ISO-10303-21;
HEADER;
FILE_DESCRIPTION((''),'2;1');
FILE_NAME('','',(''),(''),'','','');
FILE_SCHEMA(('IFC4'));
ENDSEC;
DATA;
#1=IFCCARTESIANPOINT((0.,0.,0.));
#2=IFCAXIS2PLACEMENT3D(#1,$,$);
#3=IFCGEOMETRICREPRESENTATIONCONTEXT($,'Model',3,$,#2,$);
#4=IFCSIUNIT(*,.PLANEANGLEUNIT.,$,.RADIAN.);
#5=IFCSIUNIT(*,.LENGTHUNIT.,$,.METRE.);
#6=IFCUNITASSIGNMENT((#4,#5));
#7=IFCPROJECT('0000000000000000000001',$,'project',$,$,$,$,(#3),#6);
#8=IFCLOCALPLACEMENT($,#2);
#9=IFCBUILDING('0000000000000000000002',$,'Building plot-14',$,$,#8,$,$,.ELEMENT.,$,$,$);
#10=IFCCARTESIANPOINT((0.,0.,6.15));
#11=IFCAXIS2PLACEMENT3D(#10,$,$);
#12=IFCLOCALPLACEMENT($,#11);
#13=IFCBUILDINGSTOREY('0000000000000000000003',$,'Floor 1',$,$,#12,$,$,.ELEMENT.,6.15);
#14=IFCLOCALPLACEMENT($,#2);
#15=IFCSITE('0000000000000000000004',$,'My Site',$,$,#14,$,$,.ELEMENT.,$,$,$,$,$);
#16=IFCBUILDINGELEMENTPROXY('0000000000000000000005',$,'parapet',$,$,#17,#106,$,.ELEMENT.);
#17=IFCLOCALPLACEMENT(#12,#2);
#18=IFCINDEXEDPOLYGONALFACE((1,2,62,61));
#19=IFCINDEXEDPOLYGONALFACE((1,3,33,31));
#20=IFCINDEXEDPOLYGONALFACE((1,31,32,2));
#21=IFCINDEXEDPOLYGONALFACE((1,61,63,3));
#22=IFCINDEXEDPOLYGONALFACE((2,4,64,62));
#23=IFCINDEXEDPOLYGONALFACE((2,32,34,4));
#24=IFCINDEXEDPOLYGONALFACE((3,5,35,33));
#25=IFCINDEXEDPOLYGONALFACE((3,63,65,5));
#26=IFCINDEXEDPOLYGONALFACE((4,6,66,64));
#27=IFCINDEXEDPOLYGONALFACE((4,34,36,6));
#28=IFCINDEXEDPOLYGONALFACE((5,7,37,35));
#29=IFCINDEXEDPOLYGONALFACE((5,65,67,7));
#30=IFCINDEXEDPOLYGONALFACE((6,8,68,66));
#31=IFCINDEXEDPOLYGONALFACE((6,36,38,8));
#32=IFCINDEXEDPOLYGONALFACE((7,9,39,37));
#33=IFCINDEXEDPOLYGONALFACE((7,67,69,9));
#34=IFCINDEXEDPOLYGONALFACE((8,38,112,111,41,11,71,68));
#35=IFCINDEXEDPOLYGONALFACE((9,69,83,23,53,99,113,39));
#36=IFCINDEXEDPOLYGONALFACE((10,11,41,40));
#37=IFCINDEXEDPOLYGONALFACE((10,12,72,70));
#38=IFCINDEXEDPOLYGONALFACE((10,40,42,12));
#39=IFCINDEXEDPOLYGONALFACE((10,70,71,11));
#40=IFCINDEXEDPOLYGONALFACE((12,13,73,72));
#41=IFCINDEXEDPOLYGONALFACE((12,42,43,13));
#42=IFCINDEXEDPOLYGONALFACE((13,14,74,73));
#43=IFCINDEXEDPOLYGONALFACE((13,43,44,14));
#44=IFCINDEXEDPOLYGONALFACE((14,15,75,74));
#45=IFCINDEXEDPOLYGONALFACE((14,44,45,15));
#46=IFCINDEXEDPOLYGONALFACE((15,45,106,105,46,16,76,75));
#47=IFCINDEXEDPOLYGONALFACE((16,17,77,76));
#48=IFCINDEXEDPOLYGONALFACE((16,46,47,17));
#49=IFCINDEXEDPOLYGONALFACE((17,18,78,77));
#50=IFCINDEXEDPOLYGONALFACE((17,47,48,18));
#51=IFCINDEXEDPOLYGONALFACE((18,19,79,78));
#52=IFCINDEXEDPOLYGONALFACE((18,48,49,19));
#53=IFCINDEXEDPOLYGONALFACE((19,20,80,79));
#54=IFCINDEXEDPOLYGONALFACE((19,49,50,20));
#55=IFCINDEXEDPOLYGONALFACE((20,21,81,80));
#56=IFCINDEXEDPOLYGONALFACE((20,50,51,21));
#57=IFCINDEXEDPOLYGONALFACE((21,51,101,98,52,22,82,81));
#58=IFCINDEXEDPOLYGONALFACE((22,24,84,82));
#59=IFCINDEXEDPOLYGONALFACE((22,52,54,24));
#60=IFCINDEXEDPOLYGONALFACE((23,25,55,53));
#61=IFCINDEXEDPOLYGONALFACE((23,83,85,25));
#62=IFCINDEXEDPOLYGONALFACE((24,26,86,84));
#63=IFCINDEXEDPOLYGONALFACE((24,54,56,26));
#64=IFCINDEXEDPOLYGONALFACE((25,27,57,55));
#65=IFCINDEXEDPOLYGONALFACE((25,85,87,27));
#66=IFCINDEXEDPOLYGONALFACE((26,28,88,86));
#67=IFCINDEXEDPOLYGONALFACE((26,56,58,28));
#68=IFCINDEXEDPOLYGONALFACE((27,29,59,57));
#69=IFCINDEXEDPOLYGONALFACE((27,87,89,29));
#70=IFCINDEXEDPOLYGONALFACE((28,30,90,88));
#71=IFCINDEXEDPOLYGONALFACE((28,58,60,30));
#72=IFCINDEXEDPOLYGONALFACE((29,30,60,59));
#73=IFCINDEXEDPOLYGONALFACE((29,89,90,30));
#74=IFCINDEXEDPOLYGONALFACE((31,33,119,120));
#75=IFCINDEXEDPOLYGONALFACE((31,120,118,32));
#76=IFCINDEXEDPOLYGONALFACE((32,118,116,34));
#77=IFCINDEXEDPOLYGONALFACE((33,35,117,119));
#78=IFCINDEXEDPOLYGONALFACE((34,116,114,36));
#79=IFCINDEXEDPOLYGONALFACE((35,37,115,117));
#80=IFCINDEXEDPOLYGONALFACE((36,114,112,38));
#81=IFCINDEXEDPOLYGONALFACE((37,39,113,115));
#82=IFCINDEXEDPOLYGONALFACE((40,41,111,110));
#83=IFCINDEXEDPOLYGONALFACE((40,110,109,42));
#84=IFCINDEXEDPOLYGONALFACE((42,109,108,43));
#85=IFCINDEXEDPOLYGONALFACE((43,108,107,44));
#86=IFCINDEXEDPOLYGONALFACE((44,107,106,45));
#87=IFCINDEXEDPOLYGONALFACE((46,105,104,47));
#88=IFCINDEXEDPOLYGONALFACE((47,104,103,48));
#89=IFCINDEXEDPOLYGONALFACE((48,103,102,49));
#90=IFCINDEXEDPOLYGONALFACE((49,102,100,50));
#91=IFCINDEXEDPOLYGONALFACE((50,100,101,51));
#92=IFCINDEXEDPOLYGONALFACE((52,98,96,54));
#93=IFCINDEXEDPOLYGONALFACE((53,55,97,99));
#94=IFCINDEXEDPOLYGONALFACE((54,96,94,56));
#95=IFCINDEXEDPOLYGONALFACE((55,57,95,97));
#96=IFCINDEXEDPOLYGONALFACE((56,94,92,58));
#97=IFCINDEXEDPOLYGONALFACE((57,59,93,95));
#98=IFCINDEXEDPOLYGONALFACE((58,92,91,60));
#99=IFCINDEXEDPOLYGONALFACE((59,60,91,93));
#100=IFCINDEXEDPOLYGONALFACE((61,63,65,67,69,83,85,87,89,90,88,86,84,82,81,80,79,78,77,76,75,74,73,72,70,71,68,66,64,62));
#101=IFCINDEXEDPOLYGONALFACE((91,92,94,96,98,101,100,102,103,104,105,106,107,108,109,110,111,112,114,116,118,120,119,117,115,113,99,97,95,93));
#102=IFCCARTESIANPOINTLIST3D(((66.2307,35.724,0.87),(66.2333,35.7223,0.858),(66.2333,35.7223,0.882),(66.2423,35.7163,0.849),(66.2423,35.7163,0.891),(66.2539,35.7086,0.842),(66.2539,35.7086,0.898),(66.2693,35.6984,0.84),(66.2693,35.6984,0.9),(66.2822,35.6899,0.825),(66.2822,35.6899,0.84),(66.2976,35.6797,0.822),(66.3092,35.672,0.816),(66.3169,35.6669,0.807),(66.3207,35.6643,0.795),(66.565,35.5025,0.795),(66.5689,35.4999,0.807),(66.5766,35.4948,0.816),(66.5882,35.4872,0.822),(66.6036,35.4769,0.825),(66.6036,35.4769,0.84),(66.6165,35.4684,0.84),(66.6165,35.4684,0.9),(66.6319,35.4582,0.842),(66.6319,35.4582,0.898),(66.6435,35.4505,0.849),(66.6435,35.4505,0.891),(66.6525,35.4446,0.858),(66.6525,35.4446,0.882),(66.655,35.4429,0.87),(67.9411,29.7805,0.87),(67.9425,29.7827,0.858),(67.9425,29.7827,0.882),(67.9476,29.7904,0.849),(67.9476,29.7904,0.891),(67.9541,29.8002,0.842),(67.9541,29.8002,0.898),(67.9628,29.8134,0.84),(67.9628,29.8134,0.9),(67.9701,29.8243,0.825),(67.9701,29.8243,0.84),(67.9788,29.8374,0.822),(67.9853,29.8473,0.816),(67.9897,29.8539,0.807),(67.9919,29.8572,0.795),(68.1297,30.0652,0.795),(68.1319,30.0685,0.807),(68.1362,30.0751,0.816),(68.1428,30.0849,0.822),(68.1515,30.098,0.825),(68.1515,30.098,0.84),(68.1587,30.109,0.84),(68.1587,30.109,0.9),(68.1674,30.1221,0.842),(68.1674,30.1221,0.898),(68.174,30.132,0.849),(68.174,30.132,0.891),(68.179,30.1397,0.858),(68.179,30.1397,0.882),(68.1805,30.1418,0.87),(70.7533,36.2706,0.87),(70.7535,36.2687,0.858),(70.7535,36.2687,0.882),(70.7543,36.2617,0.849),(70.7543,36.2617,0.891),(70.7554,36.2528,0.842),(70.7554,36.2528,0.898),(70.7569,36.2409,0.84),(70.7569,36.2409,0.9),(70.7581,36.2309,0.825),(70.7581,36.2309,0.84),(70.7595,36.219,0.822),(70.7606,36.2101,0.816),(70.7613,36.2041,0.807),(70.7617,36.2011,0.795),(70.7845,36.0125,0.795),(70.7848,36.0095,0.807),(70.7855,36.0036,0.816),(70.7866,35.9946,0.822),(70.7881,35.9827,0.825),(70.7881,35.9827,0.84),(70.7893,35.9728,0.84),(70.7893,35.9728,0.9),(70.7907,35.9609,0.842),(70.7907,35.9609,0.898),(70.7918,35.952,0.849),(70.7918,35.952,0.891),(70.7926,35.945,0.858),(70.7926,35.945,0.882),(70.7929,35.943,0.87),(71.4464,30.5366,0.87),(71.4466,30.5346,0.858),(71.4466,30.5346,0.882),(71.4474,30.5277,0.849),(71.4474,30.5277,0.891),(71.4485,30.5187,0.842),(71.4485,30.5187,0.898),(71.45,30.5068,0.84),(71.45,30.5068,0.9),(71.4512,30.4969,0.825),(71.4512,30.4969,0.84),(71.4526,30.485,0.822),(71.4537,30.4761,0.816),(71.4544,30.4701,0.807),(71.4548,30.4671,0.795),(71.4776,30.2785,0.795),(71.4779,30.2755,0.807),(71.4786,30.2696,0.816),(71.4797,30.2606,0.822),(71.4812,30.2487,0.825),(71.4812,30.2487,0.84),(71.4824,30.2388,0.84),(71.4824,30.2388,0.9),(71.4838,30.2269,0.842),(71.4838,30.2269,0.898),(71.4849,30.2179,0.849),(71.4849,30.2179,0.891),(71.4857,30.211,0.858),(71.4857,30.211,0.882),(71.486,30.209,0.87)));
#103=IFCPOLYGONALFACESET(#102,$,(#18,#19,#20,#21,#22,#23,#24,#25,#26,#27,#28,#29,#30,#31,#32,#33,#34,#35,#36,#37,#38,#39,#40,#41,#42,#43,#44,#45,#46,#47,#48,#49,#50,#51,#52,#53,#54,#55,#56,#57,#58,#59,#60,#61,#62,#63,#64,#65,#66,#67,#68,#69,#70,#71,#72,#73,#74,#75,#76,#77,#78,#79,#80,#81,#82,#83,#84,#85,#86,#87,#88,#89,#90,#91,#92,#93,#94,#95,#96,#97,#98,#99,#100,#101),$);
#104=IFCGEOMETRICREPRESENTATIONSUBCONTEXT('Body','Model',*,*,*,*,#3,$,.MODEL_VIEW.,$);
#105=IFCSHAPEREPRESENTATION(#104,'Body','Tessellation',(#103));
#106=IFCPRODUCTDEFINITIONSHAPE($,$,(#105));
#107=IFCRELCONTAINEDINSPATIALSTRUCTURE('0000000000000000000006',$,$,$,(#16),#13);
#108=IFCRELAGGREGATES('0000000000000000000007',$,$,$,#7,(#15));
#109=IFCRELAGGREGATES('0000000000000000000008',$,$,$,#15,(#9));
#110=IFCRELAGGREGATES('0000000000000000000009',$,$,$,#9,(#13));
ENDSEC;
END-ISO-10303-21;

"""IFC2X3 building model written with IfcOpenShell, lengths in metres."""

from ifc_helpers import new_model, entity, si_unit, frame, origin, place, context, subcontext, project, spatial, element, save


model = new_model("IFC2X3")

# Units and contexts
model_context = context("Model", 3, world=origin())
body_context = subcontext(model_context, "Body", "Model", "MODEL_VIEW")
ifc_project = project(units=[si_unit("PLANEANGLEUNIT", "RADIAN"), si_unit("LENGTHUNIT", "METRE")], contexts=[model_context])

# Site, building, storey
site_placement = place(None, origin())
site = spatial("IfcSite", under=ifc_project, at=site_placement, Name="My Site", CompositionType="ELEMENT")
building_placement = place(None, origin())
building = spatial("IfcBuilding", under=site, at=building_placement, Name="Building plot-14", CompositionType="ELEMENT")
storey_placement = place(None, frame((0.0, 0.0, 6.15)))
storey = spatial("IfcBuildingStorey", under=building, at=storey_placement, Name="Floor 1", CompositionType="ELEMENT", Elevation=6.15)

# Building element proxy
proxy_1_placement = place(storey_placement, origin())
axis2_placement3_d_1 = entity("IfcAxis2Placement3D", entity("IfcCartesianPoint", [0.0, 0.0, 0.0]))
element("IfcBuildingElementProxy", 1, at=proxy_1_placement, inside=storey, Name="parapet", CompositionType="ELEMENT", context=body_context, shape_type="SweptSolid", held_by="IfcProductRepresentation", body=[
    entity("IfcSurfaceCurveSweptAreaSolid", entity("IfcArbitraryClosedProfileDef", "AREA", None, entity("IfcPolyline", [entity("IfcCartesianPoint", [0.795, 0.265]), entity("IfcCartesianPoint", [0.807, 0.268]), entity("IfcCartesianPoint", [0.816, 0.274]), entity("IfcCartesianPoint", [0.822, 0.283]), entity("IfcCartesianPoint", [0.825, 0.295]), entity("IfcCartesianPoint", [0.84, 0.295]), entity("IfcCartesianPoint", [0.84, 0.305]), entity("IfcCartesianPoint", [0.842, 0.317]), entity("IfcCartesianPoint", [0.849, 0.326]), entity("IfcCartesianPoint", [0.858, 0.333]), entity("IfcCartesianPoint", [0.87, 0.335]), entity("IfcCartesianPoint", [0.882, 0.333]), entity("IfcCartesianPoint", [0.891, 0.326]), entity("IfcCartesianPoint", [0.898, 0.317]), entity("IfcCartesianPoint", [0.9, 0.305]), entity("IfcCartesianPoint", [0.9, 0.035]), entity("IfcCartesianPoint", [0.898, 0.023]), entity("IfcCartesianPoint", [0.891, 0.014]), entity("IfcCartesianPoint", [0.882, 0.007]), entity("IfcCartesianPoint", [0.87, 0.005]), entity("IfcCartesianPoint", [0.858, 0.007]), entity("IfcCartesianPoint", [0.849, 0.014]), entity("IfcCartesianPoint", [0.842, 0.023]), entity("IfcCartesianPoint", [0.84, 0.035]), entity("IfcCartesianPoint", [0.84, 0.045]), entity("IfcCartesianPoint", [0.825, 0.045]), entity("IfcCartesianPoint", [0.822, 0.057]), entity("IfcCartesianPoint", [0.816, 0.066]), entity("IfcCartesianPoint", [0.807, 0.072]), entity("IfcCartesianPoint", [0.795, 0.075]), entity("IfcCartesianPoint", [0.795, 0.265])])), axis2_placement3_d_1, entity("IfcPolyline", [entity("IfcCartesianPoint", [70.7935, 35.9381]), entity("IfcCartesianPoint", [66.6615, 35.4386]), entity("IfcCartesianPoint", [68.1841, 30.1473]), entity("IfcCartesianPoint", [71.4458, 30.5416])]), 0.0, 1.0, entity("IfcPlane", axis2_placement3_d_1)),
])

save(model, "model.ifc")
